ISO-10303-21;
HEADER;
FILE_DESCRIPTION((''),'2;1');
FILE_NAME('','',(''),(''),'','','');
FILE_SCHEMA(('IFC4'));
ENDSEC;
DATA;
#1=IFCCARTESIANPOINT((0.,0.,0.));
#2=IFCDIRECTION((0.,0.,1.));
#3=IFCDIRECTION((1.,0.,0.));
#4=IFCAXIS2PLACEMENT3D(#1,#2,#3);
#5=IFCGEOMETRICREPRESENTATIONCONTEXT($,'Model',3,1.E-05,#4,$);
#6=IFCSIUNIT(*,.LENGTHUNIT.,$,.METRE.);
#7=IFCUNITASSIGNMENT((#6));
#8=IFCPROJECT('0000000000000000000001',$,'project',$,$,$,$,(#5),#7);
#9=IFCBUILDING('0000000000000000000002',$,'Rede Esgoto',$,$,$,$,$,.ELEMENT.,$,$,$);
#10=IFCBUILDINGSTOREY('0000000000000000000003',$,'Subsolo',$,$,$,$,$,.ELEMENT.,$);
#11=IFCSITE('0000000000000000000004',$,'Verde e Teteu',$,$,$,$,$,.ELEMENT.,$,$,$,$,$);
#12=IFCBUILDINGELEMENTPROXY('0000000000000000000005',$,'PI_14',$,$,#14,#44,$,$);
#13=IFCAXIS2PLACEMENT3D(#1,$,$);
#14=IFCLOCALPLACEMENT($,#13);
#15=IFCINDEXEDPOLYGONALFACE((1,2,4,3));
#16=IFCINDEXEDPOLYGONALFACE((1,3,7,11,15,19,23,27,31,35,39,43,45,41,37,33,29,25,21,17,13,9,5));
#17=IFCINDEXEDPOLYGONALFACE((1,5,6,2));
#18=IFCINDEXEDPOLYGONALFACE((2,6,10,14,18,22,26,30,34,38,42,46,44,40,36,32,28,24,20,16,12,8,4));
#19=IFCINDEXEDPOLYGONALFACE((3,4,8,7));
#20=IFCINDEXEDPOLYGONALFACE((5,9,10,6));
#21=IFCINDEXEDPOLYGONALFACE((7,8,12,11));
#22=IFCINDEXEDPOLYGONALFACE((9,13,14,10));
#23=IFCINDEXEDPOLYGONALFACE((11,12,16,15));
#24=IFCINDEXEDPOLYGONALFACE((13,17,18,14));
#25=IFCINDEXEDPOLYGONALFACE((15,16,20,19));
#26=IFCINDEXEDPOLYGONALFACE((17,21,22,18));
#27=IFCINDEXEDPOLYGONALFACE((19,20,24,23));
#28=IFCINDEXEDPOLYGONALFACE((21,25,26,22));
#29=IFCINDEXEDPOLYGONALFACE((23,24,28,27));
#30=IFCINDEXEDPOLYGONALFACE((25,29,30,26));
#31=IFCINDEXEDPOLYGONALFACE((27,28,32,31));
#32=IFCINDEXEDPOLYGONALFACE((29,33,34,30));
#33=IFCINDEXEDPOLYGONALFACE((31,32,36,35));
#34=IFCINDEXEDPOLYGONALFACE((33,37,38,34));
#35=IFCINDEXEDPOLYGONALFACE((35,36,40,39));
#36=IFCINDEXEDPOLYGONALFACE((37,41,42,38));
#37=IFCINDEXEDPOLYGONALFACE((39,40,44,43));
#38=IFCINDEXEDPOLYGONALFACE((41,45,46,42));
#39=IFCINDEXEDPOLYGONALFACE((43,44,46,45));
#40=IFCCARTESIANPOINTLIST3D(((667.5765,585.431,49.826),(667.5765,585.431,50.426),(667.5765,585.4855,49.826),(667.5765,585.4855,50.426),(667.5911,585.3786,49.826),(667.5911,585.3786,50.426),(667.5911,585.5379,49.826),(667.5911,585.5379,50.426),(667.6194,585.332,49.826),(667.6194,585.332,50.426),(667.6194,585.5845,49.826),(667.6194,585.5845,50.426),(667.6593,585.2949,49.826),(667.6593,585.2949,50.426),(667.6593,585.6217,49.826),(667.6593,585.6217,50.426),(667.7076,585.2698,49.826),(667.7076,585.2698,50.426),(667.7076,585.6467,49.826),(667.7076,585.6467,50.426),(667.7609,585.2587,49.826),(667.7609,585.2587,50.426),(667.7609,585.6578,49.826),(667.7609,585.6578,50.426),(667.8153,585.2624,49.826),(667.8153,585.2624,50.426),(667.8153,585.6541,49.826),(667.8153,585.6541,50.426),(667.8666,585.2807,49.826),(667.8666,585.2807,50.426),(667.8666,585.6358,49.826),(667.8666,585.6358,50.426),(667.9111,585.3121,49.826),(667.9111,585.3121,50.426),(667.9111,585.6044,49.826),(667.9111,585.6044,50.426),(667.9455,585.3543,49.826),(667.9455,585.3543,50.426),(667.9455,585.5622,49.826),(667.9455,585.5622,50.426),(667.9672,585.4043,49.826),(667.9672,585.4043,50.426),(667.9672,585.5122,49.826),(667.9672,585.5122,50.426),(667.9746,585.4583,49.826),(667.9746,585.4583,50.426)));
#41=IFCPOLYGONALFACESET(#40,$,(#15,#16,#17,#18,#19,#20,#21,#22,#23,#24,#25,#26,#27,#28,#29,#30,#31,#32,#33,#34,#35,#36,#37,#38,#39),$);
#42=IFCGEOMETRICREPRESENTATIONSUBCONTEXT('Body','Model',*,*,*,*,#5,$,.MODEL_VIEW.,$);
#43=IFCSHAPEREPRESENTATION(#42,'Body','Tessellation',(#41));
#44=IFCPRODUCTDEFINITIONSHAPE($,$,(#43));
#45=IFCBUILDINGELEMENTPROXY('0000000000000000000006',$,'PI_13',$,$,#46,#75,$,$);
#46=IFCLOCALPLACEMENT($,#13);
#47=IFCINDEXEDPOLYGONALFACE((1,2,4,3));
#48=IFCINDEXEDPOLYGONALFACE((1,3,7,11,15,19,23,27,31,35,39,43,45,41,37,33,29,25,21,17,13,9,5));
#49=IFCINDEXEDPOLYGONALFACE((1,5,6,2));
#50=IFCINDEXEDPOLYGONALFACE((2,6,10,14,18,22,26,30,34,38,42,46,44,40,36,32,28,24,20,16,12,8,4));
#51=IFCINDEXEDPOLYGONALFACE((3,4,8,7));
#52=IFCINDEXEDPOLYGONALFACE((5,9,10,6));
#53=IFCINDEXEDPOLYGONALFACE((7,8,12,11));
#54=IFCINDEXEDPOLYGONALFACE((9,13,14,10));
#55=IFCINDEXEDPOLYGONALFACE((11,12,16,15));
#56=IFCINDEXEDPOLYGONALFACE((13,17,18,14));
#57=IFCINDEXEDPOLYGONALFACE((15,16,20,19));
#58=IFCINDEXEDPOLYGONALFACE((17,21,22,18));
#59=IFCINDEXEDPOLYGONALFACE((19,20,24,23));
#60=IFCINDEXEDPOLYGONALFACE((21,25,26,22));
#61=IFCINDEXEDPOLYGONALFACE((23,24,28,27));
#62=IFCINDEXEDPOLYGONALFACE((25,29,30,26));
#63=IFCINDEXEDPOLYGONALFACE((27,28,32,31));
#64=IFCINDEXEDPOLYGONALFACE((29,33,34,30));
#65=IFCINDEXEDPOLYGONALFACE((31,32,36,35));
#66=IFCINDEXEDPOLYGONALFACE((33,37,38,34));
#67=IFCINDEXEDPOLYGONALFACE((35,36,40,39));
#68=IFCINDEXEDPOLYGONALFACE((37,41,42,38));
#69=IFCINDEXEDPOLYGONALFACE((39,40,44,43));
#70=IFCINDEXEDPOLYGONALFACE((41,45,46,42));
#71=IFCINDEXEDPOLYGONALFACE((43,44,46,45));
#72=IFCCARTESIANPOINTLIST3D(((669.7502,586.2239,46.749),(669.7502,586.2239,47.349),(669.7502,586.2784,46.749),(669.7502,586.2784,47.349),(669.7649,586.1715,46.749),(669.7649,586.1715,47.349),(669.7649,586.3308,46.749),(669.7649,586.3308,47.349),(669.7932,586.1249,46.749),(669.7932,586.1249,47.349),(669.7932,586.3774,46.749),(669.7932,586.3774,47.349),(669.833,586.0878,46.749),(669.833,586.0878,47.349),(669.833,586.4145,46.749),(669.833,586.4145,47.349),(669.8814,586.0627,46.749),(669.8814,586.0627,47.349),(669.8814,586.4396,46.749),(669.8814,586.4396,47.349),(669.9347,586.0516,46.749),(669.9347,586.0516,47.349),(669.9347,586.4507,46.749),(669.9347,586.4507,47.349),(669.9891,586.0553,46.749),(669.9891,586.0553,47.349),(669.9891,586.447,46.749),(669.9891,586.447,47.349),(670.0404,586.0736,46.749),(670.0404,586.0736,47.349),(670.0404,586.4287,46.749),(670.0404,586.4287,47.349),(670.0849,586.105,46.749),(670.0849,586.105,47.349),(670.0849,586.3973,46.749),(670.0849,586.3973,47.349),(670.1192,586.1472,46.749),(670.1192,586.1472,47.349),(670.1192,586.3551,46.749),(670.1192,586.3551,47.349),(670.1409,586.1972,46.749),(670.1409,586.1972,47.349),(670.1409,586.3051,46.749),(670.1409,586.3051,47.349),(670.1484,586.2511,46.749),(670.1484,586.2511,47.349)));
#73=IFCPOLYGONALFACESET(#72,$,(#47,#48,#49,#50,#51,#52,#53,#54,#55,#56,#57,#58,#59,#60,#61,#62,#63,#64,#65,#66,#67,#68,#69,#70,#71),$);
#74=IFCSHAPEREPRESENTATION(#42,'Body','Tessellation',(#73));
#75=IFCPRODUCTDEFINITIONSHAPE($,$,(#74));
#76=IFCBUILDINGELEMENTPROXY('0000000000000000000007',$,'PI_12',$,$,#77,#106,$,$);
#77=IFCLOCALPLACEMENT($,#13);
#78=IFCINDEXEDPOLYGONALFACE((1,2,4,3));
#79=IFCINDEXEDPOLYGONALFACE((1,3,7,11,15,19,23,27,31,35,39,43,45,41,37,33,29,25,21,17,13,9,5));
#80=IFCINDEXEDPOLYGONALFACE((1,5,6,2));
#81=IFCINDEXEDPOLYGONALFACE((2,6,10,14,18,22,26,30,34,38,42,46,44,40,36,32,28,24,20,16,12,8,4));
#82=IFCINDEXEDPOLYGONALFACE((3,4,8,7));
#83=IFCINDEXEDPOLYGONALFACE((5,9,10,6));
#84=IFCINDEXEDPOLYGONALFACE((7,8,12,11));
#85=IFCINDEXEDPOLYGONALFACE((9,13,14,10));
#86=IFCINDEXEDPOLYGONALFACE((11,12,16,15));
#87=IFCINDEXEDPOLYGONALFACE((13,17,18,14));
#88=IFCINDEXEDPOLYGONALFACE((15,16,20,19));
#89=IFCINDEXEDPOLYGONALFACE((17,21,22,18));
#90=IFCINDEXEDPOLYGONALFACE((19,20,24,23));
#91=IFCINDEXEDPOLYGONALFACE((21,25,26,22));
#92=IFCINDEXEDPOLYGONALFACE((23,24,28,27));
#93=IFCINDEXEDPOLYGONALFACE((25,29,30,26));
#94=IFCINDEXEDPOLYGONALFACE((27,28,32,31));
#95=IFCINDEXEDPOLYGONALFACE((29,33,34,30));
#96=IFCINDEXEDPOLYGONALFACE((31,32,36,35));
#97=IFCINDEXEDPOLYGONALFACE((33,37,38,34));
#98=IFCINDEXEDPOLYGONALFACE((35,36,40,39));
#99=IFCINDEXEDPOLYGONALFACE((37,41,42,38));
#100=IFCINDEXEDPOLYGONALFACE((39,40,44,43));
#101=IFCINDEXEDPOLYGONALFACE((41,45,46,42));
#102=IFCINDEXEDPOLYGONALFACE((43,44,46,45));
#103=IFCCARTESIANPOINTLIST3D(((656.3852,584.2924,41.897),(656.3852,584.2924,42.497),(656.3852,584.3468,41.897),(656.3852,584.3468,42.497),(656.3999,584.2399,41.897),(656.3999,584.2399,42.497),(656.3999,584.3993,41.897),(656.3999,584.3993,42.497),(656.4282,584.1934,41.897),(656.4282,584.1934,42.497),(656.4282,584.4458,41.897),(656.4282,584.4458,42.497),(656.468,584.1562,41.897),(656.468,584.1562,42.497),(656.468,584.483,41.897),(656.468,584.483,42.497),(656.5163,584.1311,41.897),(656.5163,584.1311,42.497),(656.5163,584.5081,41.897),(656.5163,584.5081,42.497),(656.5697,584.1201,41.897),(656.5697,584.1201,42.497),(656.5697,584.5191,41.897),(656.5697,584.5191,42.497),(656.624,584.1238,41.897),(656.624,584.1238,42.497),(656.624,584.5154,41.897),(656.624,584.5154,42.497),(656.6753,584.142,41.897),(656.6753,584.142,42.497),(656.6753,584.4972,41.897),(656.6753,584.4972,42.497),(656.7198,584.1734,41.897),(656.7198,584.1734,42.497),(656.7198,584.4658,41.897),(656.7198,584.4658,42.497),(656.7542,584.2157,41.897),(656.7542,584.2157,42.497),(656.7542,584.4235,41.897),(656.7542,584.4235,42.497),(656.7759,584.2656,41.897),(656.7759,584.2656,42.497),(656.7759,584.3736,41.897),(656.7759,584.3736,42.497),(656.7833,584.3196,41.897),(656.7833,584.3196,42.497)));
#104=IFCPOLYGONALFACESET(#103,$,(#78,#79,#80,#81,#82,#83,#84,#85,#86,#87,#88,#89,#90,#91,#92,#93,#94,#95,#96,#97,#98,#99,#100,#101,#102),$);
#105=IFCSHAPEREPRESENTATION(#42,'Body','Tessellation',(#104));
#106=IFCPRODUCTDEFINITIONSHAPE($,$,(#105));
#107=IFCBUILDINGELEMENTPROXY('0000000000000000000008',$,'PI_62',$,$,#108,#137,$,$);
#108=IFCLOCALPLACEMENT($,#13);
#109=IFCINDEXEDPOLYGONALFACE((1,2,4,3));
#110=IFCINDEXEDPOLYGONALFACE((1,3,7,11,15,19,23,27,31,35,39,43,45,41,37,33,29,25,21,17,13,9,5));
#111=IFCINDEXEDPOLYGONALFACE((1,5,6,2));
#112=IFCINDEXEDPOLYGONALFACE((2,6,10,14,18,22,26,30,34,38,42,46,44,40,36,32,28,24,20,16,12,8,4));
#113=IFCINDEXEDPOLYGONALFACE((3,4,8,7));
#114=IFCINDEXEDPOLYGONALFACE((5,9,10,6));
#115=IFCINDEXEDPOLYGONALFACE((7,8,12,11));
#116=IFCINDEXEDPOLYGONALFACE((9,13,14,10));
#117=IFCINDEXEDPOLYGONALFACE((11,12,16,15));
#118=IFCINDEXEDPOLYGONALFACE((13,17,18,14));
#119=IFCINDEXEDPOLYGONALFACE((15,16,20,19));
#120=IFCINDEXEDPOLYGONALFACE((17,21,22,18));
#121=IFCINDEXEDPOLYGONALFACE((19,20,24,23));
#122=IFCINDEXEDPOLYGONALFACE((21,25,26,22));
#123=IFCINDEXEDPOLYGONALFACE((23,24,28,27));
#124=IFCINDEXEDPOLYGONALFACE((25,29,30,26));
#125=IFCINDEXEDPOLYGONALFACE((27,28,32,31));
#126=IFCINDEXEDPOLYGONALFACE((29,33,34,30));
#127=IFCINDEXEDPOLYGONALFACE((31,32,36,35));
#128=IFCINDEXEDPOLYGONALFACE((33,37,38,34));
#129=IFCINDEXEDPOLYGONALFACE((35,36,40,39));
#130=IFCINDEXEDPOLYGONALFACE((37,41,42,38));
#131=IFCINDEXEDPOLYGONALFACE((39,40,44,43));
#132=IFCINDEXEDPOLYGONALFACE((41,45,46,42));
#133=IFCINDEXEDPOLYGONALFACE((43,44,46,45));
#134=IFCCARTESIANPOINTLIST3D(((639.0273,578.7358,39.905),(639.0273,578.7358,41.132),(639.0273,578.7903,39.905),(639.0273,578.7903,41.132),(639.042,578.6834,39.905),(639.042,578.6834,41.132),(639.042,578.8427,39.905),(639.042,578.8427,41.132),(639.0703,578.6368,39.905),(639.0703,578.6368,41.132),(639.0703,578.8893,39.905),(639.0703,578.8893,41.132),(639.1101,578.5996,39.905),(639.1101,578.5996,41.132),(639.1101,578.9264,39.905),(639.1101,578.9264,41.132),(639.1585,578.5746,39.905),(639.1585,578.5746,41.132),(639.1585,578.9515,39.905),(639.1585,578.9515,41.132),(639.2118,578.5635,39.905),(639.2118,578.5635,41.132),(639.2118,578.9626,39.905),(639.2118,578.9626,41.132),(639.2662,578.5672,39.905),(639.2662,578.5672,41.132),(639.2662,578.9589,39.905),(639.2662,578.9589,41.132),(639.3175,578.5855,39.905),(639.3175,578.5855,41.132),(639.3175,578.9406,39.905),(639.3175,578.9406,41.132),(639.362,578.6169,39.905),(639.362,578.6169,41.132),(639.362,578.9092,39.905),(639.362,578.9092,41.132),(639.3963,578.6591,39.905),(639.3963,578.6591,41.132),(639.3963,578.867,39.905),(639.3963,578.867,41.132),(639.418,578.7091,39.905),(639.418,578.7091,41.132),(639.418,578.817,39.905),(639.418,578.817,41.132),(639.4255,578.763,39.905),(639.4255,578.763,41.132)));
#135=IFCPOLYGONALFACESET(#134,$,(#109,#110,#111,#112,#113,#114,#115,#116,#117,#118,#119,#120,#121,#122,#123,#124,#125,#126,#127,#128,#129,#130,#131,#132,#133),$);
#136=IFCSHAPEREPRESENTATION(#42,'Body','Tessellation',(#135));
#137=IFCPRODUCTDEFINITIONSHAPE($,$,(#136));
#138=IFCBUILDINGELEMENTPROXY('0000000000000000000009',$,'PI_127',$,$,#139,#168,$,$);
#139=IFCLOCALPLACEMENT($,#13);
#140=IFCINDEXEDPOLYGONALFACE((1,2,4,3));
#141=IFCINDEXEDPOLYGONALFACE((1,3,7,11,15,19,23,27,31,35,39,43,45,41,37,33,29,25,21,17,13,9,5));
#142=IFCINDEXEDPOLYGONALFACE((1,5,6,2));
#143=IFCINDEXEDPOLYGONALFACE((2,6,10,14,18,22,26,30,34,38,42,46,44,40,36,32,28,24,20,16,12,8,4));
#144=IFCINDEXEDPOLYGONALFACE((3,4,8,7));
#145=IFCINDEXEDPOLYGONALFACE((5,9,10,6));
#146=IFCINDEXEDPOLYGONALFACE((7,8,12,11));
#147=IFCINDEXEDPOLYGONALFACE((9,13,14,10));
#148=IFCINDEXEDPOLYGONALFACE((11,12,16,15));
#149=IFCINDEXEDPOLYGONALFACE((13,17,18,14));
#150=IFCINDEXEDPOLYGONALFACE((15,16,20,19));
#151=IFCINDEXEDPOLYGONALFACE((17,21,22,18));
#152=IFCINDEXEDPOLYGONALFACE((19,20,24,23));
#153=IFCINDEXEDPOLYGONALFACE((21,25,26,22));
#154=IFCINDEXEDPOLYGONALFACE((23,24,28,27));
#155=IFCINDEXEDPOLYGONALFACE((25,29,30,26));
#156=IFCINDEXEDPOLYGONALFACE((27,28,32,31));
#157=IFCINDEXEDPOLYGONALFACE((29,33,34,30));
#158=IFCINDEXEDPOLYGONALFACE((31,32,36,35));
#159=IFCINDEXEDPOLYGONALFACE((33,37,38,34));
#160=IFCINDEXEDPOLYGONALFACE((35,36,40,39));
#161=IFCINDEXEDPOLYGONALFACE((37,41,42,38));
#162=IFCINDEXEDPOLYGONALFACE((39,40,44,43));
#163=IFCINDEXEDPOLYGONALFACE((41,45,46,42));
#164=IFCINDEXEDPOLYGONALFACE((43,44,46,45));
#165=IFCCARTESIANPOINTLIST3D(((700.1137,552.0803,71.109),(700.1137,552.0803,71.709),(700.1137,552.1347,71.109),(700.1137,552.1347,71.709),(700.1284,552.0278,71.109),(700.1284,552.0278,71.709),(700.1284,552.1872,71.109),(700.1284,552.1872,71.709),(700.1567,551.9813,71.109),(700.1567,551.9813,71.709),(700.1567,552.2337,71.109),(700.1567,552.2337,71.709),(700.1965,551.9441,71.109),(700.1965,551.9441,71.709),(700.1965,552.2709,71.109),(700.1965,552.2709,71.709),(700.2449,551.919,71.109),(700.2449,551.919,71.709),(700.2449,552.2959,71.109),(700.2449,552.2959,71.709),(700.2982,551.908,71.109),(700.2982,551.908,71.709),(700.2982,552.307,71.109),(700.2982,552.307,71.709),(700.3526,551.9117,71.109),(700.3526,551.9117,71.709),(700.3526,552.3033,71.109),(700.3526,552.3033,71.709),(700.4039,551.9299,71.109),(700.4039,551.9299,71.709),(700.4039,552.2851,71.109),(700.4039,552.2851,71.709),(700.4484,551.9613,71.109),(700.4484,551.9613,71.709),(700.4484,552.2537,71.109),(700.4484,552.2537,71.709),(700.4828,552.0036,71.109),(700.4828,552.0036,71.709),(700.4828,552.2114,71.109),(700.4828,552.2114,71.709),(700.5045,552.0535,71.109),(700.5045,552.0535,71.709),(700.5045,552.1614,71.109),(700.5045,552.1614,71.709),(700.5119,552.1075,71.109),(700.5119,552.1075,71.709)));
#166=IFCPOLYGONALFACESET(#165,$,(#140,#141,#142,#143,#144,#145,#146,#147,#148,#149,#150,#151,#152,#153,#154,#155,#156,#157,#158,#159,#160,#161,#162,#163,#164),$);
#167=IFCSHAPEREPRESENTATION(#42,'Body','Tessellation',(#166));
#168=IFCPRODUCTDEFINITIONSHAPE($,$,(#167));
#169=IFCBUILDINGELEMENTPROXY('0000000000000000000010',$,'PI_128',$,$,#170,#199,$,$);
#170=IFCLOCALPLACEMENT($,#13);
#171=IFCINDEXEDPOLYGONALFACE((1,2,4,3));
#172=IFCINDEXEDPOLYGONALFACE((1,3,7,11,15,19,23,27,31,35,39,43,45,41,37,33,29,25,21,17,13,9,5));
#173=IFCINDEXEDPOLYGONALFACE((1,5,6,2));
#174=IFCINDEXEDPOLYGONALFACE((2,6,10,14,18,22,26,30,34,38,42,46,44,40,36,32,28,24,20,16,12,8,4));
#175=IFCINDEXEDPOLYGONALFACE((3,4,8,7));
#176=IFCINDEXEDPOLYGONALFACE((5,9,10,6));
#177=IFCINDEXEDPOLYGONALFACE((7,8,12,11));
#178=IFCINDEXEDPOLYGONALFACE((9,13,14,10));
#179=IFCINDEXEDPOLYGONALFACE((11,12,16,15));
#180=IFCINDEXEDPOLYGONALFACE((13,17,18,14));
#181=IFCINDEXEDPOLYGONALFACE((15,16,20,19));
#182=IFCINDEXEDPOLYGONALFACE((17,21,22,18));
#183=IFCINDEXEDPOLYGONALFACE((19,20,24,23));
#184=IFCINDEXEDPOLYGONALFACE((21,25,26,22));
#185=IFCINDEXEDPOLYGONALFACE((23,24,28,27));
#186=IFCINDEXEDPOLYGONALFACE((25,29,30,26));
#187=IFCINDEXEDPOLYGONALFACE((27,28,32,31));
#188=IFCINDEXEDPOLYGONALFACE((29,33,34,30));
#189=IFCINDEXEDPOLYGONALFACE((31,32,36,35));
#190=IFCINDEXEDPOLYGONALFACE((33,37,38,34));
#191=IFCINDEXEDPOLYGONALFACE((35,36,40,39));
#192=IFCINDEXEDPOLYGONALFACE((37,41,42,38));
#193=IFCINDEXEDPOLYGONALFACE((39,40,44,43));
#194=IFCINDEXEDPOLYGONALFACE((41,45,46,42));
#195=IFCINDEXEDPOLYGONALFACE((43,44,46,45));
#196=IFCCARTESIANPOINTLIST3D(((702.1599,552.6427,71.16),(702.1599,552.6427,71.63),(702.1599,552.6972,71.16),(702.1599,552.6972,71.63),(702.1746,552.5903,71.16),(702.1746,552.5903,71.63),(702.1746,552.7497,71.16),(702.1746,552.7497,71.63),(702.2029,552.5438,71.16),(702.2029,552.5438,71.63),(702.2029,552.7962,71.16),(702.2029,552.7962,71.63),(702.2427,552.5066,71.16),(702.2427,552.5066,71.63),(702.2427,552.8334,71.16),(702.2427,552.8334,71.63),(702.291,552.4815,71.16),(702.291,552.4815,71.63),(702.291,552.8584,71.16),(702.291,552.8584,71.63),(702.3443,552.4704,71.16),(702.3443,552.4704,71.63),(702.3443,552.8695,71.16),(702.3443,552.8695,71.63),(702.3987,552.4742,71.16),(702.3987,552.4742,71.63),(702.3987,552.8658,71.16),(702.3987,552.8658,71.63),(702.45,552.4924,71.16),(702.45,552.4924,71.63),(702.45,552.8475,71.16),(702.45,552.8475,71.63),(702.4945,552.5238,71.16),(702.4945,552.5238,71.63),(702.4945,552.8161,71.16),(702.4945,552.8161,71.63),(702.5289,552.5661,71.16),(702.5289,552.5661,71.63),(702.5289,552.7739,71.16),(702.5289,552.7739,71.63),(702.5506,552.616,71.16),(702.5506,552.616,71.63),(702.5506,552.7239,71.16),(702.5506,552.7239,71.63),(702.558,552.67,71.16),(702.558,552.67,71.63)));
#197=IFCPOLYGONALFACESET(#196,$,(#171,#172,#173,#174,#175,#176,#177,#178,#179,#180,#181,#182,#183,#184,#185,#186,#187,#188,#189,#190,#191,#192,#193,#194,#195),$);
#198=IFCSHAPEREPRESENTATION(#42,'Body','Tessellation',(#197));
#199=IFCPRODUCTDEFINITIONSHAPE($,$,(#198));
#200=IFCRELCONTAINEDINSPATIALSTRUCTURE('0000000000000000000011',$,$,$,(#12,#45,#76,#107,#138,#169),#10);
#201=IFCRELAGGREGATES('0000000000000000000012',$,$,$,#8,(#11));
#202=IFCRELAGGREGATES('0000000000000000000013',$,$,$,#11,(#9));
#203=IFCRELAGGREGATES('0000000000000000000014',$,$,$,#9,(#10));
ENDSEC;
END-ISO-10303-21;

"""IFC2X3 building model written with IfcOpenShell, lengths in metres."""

from ifc_helpers import new_model, si_unit, frame, origin_with_axes, origin_2d, place, context, subcontext, project, spatial, circle, extrude, element, save


model = new_model("IFC2X3")

# Units and contexts
model_context = context("Model", 3, precision=1e-05, world=origin_with_axes())
body_context = subcontext(model_context, "Body", "Model", "MODEL_VIEW")
ifc_project = project(units=[si_unit("LENGTHUNIT", "METRE")], contexts=[model_context])

# Site, building, storey
site = spatial("IfcSite", under=ifc_project, Name="Verde e Teteu", CompositionType="ELEMENT")
building = spatial("IfcBuilding", under=site, Name="Rede Esgoto", CompositionType="ELEMENT")
storey = spatial("IfcBuildingStorey", under=building, Name="Subsolo", CompositionType="ELEMENT")

# Building element proxies
for number, where, z_axis, x_axis, name in (
    (1, (667.7746, 585.4583, 49.826), (0.0, 0.0, 1.0), (1.0, 0.0, 0.0), "PI_14"),
):
    element("IfcBuildingElementProxy", number, at=place(None, frame(where, z_axis=z_axis, x_axis=x_axis)), inside=storey, Name=name, context=body_context, shape_type="SweptSolid", body=[
        extrude(circle(Radius=0.2, at=origin_2d()), origin_with_axes(), (0.0, 0.0, 1.0), 0.6),
    ])
proxy_1_placement = place(None, frame((669.9484, 586.2511, 46.749), z_axis=(0.0, 0.0, 1.0), x_axis=(1.0, 0.0, 0.0)))
element("IfcBuildingElementProxy", 2, at=proxy_1_placement, inside=storey, Name="PI_13", context=body_context, shape_type="SweptSolid", body=[
    extrude(circle(Radius=0.2, at=origin_2d()), origin_with_axes(), (0.0, 0.0, 1.0), 0.6),
])
proxy_2_placement = place(None, frame((656.5833, 584.3196, 41.897), z_axis=(0.0, 0.0, 1.0), x_axis=(1.0, 0.0, 0.0)))
element("IfcBuildingElementProxy", 3, at=proxy_2_placement, inside=storey, Name="PI_12", context=body_context, shape_type="SweptSolid", body=[
    extrude(circle(Radius=0.2, at=origin_2d()), origin_with_axes(), (0.0, 0.0, 1.0), 0.6),
])
proxy_3_placement = place(None, frame((639.2255, 578.763, 39.905), z_axis=(0.0, 0.0, 1.0), x_axis=(1.0, 0.0, 0.0)))
element("IfcBuildingElementProxy", 4, at=proxy_3_placement, inside=storey, Name="PI_62", context=body_context, shape_type="SweptSolid", body=[
    extrude(circle(Radius=0.2, at=origin_2d()), origin_with_axes(), (0.0, 0.0, 1.0), 1.227),
])
proxy_4_placement = place(None, frame((700.3119, 552.1075, 71.109), z_axis=(0.0, 0.0, 1.0), x_axis=(1.0, 0.0, 0.0)))
element("IfcBuildingElementProxy", 5, at=proxy_4_placement, inside=storey, Name="PI_127", context=body_context, shape_type="SweptSolid", body=[
    extrude(circle(Radius=0.2, at=origin_2d()), origin_with_axes(), (0.0, 0.0, 1.0), 0.6),
])
proxy_5_placement = place(None, frame((702.358, 552.67, 71.16), z_axis=(0.0, 0.0, 1.0), x_axis=(1.0, 0.0, 0.0)))
element("IfcBuildingElementProxy", 6, at=proxy_5_placement, inside=storey, Name="PI_128", context=body_context, shape_type="SweptSolid", body=[
    extrude(circle(Radius=0.2, at=origin_2d()), origin_with_axes(), (0.0, 0.0, 1.0), 0.47),
])

save(model, "model.ifc")
